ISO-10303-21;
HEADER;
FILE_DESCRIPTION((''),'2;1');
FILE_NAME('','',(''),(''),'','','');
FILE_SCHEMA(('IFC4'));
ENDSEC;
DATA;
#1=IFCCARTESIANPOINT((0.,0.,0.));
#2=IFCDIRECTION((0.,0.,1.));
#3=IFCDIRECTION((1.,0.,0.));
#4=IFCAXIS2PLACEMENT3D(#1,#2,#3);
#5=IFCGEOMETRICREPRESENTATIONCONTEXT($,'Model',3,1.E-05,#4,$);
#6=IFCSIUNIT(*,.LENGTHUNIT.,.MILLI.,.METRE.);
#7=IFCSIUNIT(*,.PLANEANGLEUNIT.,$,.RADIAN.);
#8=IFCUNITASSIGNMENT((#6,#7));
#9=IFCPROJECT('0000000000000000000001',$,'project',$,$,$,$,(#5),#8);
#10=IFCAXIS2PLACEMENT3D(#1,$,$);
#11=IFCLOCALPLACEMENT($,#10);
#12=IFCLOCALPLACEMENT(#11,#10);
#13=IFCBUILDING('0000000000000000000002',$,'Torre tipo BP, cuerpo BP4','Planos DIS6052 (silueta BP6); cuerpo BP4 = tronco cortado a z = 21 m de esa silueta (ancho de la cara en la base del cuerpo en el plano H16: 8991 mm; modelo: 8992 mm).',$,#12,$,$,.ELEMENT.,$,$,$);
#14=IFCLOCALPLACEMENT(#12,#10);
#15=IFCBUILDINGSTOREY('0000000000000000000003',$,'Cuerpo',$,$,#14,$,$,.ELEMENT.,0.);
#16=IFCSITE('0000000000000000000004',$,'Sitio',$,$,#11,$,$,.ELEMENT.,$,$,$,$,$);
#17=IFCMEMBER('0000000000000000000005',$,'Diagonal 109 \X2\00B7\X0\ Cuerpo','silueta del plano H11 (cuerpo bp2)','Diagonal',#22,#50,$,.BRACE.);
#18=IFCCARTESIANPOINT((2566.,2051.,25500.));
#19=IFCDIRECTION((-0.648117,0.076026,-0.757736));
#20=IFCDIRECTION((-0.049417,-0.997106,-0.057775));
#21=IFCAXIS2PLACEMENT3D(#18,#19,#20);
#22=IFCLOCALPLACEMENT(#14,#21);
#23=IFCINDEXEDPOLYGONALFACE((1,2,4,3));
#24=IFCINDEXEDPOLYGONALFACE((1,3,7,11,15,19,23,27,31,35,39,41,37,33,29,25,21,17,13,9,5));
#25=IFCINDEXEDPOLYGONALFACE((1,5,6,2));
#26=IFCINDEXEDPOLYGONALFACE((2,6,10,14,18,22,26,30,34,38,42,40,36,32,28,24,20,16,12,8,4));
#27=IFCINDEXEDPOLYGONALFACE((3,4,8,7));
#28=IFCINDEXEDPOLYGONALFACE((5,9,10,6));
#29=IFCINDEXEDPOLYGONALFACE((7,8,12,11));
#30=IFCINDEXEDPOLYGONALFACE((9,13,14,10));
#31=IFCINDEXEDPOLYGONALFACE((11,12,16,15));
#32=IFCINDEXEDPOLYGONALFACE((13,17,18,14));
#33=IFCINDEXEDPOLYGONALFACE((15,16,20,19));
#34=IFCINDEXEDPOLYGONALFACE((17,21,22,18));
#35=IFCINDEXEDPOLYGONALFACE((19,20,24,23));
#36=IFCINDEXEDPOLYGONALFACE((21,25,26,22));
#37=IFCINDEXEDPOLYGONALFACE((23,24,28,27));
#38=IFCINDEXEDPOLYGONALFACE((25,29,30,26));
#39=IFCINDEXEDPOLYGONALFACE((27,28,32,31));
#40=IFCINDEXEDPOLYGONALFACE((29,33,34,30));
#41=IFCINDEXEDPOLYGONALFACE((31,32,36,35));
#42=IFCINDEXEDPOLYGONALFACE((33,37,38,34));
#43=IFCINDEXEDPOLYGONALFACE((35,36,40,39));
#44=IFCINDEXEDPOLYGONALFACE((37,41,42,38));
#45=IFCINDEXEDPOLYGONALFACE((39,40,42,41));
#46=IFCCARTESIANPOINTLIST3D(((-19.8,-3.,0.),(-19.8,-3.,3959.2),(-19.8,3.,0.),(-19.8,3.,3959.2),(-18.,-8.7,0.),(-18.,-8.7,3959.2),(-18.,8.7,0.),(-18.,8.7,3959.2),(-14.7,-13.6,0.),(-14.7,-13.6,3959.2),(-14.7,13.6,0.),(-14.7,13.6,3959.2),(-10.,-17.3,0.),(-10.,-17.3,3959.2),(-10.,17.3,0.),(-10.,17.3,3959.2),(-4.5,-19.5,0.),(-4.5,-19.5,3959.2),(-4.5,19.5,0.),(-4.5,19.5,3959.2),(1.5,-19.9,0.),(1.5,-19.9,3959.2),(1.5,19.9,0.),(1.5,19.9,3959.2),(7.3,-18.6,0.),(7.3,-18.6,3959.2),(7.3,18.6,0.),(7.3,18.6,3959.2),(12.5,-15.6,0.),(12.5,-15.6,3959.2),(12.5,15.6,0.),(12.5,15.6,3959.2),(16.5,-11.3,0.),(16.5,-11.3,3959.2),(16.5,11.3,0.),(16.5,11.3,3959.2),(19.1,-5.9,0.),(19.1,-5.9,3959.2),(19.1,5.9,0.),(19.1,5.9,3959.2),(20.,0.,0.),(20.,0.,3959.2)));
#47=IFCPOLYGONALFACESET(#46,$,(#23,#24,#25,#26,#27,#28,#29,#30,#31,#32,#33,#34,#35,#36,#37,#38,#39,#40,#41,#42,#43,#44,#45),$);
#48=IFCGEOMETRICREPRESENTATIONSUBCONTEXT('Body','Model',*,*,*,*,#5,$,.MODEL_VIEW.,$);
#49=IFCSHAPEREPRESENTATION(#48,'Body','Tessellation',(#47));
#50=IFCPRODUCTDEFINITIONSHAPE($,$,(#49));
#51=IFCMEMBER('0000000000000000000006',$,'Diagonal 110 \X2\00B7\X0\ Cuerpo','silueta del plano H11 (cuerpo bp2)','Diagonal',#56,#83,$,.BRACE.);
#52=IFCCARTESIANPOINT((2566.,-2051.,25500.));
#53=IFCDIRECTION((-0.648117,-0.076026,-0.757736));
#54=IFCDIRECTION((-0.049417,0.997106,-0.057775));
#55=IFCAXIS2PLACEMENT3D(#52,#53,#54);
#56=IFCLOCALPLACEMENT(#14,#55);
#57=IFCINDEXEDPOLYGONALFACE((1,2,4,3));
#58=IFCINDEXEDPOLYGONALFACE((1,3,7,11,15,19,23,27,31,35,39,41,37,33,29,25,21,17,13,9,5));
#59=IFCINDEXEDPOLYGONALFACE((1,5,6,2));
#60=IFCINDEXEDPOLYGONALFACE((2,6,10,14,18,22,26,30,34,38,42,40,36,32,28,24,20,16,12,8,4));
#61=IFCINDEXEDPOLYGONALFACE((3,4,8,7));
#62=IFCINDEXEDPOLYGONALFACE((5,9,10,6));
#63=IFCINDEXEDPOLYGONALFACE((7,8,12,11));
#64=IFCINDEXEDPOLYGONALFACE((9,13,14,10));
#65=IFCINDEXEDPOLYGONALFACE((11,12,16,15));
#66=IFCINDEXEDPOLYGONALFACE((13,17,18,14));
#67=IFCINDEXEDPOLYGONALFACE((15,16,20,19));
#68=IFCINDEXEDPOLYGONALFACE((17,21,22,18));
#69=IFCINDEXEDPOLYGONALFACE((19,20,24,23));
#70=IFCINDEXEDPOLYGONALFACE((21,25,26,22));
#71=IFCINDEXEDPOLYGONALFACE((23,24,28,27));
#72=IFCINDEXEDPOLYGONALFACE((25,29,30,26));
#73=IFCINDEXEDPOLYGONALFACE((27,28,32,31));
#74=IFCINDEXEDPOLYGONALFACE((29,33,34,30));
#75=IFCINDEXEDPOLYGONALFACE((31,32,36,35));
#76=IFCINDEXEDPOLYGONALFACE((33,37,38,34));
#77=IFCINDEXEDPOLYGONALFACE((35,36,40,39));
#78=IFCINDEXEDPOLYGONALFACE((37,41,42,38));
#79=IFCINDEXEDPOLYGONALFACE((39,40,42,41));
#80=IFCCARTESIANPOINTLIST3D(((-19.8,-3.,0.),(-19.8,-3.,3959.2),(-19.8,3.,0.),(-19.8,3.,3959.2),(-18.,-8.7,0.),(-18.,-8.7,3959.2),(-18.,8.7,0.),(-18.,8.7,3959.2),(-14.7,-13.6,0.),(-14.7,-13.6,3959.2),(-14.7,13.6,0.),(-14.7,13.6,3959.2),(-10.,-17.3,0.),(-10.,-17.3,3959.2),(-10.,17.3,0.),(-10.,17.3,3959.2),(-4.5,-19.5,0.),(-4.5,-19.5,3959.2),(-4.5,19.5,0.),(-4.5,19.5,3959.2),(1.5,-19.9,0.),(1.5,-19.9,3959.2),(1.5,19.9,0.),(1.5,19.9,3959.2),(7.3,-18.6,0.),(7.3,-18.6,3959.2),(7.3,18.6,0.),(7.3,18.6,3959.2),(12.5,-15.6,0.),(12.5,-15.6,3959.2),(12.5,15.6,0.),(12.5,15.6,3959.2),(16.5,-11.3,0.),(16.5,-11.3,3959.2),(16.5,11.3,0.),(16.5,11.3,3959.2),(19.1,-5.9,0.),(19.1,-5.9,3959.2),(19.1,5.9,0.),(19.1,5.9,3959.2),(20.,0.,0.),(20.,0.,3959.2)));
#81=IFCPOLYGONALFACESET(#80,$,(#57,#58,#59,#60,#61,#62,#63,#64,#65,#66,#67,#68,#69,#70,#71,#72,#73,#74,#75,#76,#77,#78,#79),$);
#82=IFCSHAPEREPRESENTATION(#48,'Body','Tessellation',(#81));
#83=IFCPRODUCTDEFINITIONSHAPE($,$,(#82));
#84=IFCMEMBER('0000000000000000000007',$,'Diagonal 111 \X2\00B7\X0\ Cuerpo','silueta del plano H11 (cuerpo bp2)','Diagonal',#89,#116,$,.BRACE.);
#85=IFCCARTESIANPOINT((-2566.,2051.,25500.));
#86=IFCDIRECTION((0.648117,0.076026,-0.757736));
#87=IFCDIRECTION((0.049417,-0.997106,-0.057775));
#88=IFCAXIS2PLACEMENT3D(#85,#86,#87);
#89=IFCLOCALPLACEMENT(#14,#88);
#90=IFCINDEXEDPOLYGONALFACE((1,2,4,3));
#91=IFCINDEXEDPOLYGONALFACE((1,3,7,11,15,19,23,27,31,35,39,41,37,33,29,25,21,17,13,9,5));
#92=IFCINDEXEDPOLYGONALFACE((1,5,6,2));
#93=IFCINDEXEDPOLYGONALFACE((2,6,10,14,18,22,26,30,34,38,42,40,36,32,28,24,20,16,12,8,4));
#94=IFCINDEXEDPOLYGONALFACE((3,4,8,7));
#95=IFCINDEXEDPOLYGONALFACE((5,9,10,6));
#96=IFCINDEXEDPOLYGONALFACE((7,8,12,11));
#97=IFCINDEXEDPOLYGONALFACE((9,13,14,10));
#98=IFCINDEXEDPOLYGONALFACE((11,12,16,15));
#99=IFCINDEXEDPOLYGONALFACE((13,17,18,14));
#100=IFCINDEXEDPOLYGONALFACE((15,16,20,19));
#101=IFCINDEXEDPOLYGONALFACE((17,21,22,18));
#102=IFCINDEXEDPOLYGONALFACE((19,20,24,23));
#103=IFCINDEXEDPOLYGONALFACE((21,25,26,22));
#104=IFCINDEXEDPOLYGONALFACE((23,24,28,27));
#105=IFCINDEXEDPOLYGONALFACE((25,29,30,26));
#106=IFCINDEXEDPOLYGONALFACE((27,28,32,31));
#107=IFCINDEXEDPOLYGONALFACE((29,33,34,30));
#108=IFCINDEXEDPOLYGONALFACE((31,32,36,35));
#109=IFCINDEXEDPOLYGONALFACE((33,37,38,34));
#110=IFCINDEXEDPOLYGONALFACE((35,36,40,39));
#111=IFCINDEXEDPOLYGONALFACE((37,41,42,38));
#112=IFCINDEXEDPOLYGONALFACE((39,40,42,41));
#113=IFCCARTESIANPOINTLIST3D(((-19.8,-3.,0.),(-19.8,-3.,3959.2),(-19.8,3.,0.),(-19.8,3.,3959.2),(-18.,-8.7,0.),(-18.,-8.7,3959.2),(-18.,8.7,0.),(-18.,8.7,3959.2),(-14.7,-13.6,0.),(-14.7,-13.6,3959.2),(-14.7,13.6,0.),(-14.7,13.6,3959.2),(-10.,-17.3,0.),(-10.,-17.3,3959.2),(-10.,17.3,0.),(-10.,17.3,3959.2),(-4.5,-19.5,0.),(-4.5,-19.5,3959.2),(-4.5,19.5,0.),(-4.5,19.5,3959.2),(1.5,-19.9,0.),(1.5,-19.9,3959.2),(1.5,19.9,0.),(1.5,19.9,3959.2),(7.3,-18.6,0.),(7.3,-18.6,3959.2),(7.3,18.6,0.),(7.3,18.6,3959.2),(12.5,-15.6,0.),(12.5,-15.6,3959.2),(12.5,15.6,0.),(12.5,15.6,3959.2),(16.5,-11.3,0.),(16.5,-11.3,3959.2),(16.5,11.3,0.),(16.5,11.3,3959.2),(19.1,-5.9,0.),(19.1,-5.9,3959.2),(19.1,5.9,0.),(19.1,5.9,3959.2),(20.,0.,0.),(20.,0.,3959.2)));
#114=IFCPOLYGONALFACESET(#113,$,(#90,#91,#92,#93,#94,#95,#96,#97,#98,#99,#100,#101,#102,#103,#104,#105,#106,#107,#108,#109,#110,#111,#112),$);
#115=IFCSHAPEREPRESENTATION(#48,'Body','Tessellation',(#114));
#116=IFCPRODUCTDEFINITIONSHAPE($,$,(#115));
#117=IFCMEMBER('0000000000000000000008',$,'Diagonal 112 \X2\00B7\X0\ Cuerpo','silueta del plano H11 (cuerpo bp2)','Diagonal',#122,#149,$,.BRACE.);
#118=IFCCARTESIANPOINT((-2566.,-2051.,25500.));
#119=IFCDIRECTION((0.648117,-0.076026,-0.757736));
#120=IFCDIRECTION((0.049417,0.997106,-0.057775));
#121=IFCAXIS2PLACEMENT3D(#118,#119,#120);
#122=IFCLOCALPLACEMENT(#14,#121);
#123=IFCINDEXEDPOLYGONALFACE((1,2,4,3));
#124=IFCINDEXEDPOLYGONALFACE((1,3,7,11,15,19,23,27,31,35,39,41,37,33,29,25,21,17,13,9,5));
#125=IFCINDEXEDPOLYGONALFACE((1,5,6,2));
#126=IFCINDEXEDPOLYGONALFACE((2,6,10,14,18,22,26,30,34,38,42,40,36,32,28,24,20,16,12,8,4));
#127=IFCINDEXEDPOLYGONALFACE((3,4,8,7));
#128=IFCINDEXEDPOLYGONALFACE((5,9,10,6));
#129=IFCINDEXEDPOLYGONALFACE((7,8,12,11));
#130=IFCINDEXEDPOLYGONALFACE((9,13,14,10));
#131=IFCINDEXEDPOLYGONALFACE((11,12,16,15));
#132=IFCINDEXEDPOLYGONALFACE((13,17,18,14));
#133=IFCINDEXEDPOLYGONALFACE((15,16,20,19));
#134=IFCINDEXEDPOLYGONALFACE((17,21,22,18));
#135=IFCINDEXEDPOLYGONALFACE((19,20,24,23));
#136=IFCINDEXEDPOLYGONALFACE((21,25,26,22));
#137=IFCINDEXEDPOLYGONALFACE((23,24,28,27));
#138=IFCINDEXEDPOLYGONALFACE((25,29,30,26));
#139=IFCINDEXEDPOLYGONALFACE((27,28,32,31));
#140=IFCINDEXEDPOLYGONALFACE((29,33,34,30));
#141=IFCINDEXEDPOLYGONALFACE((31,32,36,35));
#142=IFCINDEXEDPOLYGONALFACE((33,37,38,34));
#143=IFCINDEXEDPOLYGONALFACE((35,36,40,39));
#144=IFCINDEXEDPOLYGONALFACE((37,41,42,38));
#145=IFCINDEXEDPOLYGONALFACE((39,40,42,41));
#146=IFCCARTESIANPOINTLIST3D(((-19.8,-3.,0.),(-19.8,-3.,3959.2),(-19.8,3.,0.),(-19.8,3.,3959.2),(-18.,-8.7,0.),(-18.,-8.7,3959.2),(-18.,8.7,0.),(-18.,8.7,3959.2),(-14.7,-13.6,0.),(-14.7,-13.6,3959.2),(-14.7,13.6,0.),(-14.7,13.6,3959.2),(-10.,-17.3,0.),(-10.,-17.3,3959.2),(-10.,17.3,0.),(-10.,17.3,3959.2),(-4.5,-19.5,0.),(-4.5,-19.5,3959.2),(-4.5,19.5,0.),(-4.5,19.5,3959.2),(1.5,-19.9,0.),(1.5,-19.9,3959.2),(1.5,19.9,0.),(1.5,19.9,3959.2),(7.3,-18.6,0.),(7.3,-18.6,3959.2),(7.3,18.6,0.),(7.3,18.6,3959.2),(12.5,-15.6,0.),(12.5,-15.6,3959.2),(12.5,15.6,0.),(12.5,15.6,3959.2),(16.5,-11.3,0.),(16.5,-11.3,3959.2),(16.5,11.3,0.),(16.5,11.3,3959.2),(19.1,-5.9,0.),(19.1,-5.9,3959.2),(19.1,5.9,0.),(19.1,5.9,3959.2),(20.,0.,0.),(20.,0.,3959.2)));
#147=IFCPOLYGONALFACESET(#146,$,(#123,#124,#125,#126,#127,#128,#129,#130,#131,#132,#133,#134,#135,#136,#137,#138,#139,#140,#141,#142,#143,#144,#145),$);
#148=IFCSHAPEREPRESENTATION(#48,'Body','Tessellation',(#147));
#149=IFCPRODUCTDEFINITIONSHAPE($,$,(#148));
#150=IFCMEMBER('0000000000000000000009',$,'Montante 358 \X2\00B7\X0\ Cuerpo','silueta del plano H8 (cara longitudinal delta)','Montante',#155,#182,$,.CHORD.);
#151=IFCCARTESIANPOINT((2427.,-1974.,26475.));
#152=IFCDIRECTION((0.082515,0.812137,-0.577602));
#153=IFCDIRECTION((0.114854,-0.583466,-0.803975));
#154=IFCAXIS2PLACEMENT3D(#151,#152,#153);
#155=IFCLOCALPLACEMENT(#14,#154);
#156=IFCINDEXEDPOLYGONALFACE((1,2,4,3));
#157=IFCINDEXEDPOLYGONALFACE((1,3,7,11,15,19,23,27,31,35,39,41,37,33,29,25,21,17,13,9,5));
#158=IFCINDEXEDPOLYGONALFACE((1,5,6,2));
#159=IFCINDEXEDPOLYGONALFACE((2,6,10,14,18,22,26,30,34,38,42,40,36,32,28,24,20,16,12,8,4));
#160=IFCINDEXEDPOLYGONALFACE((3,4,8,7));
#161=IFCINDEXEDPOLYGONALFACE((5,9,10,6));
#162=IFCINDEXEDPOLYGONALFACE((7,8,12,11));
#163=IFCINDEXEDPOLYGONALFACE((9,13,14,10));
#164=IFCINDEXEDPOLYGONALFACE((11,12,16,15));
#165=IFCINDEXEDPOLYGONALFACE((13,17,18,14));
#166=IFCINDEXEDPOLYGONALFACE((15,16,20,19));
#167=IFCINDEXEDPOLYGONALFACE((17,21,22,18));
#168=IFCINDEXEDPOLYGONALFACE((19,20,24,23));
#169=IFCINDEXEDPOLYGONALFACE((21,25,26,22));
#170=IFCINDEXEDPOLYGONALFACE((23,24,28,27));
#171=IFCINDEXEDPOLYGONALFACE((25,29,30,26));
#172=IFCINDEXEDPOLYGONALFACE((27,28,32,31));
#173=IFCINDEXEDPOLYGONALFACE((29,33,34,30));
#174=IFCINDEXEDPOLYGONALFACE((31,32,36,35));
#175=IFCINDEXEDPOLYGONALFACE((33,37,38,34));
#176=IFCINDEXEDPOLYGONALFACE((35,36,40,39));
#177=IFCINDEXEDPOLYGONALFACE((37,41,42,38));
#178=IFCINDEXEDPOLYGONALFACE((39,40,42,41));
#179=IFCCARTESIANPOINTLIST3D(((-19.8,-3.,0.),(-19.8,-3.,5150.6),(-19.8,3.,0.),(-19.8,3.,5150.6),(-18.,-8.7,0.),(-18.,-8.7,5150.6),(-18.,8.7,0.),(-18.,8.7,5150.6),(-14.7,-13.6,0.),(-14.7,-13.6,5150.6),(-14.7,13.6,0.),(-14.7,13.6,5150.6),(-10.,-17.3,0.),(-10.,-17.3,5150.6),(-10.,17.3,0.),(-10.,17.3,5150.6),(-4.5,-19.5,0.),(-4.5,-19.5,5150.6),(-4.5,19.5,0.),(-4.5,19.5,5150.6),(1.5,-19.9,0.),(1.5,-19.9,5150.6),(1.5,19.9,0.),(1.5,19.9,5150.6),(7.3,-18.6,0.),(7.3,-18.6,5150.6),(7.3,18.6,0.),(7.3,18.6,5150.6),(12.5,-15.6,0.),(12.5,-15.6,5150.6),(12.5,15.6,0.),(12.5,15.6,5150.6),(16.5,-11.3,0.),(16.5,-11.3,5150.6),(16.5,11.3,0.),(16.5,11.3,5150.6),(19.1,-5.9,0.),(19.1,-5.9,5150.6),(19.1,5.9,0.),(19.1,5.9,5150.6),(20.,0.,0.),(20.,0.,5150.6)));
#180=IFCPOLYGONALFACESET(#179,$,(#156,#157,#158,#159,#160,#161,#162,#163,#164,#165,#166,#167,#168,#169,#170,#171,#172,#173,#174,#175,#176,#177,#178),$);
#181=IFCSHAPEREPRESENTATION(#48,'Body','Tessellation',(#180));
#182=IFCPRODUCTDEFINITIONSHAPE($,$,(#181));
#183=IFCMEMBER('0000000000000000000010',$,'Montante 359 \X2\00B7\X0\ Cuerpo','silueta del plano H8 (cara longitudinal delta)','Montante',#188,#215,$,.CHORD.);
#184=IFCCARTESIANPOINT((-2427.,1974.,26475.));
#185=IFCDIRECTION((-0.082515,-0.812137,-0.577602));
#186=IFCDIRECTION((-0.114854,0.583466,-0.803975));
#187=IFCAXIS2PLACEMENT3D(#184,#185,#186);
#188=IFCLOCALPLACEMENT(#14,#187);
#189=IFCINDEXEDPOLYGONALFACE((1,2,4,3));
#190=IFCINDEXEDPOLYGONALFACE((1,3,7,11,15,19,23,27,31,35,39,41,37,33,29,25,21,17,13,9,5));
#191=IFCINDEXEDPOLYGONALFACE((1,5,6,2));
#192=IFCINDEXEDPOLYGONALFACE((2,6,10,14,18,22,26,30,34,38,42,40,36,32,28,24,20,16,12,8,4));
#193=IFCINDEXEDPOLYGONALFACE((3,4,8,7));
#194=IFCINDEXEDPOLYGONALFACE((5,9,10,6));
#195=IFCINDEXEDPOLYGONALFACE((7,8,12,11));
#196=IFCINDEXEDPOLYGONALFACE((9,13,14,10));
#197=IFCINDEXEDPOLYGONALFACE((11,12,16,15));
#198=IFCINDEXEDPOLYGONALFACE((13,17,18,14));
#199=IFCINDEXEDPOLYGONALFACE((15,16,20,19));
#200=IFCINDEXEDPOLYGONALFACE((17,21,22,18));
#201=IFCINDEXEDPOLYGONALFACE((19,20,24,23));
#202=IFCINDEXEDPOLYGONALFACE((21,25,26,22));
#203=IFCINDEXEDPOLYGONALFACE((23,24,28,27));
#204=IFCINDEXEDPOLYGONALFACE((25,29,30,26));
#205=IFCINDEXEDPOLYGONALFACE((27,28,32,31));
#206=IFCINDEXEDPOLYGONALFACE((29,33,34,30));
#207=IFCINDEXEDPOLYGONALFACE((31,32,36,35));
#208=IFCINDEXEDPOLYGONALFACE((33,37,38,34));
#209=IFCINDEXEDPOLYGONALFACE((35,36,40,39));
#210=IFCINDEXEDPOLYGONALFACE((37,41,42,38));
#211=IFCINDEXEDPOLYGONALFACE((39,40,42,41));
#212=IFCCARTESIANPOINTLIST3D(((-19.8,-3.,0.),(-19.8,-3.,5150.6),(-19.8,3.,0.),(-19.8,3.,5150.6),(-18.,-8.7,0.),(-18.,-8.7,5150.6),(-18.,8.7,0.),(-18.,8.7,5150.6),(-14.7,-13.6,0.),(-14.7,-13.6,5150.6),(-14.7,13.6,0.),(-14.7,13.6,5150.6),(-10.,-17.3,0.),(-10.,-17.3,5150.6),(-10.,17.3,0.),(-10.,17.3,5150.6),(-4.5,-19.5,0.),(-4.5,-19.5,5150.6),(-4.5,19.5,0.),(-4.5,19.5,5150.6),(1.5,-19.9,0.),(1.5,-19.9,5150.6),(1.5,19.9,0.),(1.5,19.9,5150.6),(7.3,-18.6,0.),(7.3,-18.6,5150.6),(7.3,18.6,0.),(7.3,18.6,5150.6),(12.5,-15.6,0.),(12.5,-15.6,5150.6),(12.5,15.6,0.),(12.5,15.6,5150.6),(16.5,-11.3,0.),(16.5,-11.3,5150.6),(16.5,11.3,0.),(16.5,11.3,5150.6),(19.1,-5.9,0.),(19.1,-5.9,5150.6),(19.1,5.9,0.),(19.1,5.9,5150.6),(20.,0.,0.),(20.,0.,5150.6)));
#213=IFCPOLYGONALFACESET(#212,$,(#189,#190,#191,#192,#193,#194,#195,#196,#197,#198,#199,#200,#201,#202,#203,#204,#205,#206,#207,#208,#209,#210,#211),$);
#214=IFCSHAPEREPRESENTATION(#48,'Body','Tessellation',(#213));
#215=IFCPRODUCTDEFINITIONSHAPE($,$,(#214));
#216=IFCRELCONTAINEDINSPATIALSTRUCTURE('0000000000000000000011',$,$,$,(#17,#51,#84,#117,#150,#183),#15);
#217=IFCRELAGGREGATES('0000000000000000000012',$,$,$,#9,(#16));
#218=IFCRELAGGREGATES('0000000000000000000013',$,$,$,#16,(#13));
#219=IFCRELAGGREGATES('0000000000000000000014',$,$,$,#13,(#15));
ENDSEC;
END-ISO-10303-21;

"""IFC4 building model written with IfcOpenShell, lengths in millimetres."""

from ifc_helpers import new_model, si_unit, frame, origin, origin_with_axes, place, context, subcontext, project, spatial, circle, extrude, element, save


model = new_model("IFC4")

# Units and contexts
model_context = context("Model", 3, precision=1e-05, world=origin_with_axes())
body_context = subcontext(model_context, "Body", "Model", "MODEL_VIEW")
ifc_project = project(units=[si_unit("LENGTHUNIT", "METRE", prefix="MILLI"), si_unit("PLANEANGLEUNIT", "RADIAN")], contexts=[model_context])

# Site, building, storey
site_placement = place(None, origin())
site = spatial("IfcSite", under=ifc_project, at=site_placement, Name="Sitio", CompositionType="ELEMENT")
building_placement = place(site_placement, origin())
building = spatial("IfcBuilding", under=site, at=building_placement, Name="Torre tipo BP, cuerpo BP4", Description="Planos DIS6052 (silueta BP6); cuerpo BP4 = tronco cortado a z = 21 m de esa silueta (ancho de la cara en la base del cuerpo en el plano H16: 8991 mm; modelo: 8992 mm).", CompositionType="ELEMENT")
storey_placement = place(building_placement, origin())
storey = spatial("IfcBuildingStorey", under=building, at=storey_placement, Name="Cuerpo", CompositionType="ELEMENT", Elevation=0.0)

# Members
for number, where, z_axis, x_axis, name in (
    (1, (2566.0, 2051.0, 25500.0), (-0.648117, 0.076026, -0.757736), (-0.049417, -0.997106, -0.057775), "Diagonal 109 · Cuerpo"),
    (2, (2566.0, -2051.0, 25500.0), (-0.648117, -0.076026, -0.757736), (-0.049417, 0.997106, -0.057775), "Diagonal 110 · Cuerpo"),
    (3, (-2566.0, 2051.0, 25500.0), (0.648117, 0.076026, -0.757736), (0.049417, -0.997106, -0.057775), "Diagonal 111 · Cuerpo"),
    (4, (-2566.0, -2051.0, 25500.0), (0.648117, -0.076026, -0.757736), (0.049417, 0.997106, -0.057775), "Diagonal 112 · Cuerpo"),
):
    element("IfcMember", number, at=place(storey_placement, frame(where, z_axis=z_axis, x_axis=x_axis)), inside=storey, Name=name, Description="silueta del plano H11 (cuerpo bp2)", ObjectType="Diagonal", PredefinedType="BRACE", context=body_context, shape_type="SweptSolid", body=[
        extrude(circle(Radius=20.0), None, (0.0, 0.0, 1.0), 3959.2),
    ])
for number, where, z_axis, x_axis, name in (
    (5, (2427.0, -1974.0, 26475.0), (0.082515, 0.812137, -0.577602), (0.114854, -0.583466, -0.803975), "Montante 358 · Cuerpo"),
    (6, (-2427.0, 1974.0, 26475.0), (-0.082515, -0.812137, -0.577602), (-0.114854, 0.583466, -0.803975), "Montante 359 · Cuerpo"),
):
    element("IfcMember", number, at=place(storey_placement, frame(where, z_axis=z_axis, x_axis=x_axis)), inside=storey, Name=name, Description="silueta del plano H8 (cara longitudinal delta)", ObjectType="Montante", PredefinedType="CHORD", context=body_context, shape_type="SweptSolid", body=[
        extrude(circle(Radius=20.0), None, (0.0, 0.0, 1.0), 5150.6),
    ])

save(model, "model.ifc")
